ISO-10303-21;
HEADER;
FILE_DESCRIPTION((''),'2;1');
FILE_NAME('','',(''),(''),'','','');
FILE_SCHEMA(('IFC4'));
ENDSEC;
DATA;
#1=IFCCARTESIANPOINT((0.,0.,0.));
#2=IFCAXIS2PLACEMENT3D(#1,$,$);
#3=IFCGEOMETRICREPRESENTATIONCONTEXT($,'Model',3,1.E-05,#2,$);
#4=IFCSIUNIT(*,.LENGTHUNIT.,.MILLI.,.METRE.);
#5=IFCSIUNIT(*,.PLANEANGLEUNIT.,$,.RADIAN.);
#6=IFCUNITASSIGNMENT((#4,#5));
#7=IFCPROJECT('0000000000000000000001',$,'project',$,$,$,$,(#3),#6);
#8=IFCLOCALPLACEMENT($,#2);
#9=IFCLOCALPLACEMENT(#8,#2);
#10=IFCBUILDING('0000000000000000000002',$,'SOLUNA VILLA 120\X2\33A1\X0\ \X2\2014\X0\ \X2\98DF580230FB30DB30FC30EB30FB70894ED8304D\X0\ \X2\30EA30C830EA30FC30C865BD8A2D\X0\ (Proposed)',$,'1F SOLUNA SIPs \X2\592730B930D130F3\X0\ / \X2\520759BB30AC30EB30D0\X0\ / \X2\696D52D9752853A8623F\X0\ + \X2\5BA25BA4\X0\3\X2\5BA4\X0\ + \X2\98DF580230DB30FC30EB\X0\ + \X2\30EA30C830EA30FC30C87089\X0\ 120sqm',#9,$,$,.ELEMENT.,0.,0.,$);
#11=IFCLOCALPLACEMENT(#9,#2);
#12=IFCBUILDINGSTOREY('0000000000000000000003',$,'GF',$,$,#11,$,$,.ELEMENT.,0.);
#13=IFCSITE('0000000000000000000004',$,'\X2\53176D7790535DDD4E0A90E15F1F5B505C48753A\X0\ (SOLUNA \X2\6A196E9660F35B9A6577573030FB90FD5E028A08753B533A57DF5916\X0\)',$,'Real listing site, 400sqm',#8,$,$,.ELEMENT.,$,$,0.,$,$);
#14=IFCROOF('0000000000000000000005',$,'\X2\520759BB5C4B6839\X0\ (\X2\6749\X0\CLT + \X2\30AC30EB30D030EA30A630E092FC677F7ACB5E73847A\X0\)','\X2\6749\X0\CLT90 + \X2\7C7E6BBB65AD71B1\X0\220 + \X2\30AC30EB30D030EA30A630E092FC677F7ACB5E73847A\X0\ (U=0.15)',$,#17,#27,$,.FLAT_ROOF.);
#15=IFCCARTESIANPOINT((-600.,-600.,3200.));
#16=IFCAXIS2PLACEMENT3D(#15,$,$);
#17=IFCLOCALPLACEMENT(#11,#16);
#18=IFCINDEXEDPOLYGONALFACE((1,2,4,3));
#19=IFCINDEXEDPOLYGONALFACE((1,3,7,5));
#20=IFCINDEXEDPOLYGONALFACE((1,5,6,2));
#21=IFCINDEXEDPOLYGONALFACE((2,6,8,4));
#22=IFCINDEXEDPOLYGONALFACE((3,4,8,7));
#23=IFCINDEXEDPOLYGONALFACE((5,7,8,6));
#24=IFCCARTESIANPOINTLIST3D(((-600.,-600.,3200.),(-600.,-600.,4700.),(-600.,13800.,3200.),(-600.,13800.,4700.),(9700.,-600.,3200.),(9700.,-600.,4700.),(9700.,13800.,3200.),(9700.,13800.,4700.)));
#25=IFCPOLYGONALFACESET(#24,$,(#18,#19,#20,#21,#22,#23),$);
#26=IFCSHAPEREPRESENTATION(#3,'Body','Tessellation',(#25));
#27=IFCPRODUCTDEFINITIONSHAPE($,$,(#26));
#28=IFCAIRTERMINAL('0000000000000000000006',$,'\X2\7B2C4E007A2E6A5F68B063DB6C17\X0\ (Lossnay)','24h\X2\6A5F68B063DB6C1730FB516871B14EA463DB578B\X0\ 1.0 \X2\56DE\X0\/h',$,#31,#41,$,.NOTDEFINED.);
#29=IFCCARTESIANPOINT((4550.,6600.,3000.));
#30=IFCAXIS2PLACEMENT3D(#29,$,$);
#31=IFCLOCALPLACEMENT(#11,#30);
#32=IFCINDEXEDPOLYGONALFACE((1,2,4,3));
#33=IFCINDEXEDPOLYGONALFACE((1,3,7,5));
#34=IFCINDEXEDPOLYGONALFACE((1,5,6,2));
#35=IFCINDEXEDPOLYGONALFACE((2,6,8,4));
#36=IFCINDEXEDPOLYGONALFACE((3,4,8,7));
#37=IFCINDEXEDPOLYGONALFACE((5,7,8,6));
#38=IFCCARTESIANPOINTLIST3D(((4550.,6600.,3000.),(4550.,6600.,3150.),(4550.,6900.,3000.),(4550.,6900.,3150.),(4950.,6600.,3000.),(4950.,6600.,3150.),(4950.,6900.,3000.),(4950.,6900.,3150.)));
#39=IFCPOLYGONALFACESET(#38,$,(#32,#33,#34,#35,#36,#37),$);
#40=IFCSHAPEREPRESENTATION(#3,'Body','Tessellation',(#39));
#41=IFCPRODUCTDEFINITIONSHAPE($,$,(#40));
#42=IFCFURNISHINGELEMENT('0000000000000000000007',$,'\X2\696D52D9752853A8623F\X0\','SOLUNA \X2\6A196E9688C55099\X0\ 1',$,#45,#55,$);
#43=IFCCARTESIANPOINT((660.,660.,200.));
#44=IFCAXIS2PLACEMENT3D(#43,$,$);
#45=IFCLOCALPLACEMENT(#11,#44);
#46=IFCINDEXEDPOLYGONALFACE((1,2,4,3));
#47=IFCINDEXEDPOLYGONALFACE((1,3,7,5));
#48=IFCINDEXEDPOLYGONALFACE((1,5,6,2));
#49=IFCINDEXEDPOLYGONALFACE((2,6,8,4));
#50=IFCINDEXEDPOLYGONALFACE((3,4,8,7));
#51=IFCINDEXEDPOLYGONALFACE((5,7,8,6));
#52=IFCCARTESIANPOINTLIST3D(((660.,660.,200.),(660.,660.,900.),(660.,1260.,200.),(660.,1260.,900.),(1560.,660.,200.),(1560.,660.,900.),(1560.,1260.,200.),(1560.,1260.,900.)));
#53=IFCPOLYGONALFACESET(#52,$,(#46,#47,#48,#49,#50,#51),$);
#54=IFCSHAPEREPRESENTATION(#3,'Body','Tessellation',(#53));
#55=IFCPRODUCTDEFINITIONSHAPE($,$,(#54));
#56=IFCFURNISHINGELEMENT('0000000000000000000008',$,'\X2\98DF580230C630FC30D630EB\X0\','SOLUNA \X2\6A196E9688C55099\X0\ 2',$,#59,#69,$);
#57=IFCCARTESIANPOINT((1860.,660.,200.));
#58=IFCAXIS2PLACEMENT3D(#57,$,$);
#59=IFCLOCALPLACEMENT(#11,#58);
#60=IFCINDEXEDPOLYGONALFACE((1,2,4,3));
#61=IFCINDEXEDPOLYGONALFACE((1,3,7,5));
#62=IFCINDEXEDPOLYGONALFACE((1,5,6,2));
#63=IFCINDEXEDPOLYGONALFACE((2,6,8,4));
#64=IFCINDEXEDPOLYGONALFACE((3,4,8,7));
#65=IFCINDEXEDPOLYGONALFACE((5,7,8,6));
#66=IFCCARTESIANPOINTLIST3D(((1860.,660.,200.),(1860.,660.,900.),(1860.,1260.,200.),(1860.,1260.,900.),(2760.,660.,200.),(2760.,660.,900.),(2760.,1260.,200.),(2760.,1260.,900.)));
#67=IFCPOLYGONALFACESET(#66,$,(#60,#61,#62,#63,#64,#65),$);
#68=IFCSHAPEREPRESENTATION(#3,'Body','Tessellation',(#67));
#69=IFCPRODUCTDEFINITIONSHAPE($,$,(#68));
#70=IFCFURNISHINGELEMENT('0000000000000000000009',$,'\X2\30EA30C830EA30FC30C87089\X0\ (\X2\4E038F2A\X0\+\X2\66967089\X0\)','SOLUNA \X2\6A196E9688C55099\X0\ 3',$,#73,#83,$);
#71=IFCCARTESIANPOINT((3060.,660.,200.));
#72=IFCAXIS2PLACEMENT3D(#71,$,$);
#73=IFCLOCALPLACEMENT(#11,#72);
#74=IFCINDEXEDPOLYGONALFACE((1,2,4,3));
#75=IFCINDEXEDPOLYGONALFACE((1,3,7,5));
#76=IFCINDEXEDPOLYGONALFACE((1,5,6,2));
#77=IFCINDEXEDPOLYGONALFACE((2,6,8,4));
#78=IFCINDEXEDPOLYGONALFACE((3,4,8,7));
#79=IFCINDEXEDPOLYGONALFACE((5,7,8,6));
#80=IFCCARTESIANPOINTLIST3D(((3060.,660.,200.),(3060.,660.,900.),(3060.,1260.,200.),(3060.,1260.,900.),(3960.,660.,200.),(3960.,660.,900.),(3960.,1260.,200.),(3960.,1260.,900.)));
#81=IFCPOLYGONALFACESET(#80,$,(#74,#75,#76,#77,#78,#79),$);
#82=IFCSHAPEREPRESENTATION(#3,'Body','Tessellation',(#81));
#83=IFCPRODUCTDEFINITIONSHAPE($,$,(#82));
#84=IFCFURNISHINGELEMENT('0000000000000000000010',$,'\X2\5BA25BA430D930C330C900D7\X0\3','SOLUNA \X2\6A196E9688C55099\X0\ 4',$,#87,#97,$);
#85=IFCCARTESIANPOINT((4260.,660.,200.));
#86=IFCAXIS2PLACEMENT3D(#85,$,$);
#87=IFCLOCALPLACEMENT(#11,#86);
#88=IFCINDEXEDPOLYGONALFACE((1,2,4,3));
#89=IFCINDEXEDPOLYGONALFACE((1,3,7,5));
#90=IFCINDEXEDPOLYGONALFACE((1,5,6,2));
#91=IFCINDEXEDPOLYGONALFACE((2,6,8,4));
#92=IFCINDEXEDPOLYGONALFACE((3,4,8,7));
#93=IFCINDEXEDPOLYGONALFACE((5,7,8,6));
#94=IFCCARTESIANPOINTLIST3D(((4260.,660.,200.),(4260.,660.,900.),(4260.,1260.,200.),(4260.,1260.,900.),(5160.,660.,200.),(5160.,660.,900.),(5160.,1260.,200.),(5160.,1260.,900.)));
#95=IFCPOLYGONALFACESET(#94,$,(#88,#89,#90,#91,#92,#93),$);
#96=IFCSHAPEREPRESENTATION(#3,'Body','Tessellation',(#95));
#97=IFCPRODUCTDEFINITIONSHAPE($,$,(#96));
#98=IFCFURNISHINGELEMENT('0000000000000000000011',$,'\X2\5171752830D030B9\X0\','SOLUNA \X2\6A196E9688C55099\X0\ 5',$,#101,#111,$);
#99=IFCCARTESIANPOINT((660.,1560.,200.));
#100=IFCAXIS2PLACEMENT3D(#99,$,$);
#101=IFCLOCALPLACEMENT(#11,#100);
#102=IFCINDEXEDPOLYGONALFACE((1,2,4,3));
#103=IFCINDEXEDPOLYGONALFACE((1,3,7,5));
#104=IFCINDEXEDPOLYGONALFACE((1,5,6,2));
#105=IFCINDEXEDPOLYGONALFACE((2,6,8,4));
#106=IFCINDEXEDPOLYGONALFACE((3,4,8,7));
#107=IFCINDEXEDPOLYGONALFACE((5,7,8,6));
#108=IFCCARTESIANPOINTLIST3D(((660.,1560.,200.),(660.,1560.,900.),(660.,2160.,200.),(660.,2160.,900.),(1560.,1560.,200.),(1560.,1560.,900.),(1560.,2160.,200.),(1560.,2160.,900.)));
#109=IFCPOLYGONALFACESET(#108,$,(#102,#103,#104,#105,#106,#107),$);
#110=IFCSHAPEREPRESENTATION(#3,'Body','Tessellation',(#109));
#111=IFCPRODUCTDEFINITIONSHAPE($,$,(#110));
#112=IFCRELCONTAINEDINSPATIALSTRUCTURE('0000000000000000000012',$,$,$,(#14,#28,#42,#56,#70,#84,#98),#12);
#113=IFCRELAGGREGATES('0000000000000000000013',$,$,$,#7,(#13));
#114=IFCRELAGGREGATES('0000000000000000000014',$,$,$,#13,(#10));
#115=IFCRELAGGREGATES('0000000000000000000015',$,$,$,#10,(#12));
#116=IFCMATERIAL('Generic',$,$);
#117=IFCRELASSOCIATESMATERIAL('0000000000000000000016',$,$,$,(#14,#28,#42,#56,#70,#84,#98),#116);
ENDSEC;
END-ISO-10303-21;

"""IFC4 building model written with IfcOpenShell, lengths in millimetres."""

from ifc_helpers import new_model, si_unit, frame, frame_2d, origin, place, context, project, spatial, rectangle, extrude, material, element, save


model = new_model("IFC4")

# Units and contexts
model_context = context("Model", 3, precision=1e-05, world=origin())
ifc_project = project(units=[si_unit("LENGTHUNIT", "METRE", prefix="MILLI"), si_unit("PLANEANGLEUNIT", "RADIAN")], contexts=[model_context])

# Site, building, storey
site_placement = place(None, origin())
site = spatial("IfcSite", under=ifc_project, at=site_placement, Name="北海道川上郡弟子屈町 (SOLUNA 標準想定敷地・都市計画区域外)", ObjectType="Real listing site, 400sqm", CompositionType="ELEMENT", RefElevation=0.0)
building_placement = place(site_placement, origin())
building = spatial("IfcBuilding", under=site, at=building_placement, Name="SOLUNA VILLA 120㎡ — 食堂・ホール・炉付き リトリート施設 (Proposed)", ObjectType="1F SOLUNA SIPs 大スパン / 切妻ガルバ / 業務用厨房 + 客室3室 + 食堂ホール + リトリート炉 120sqm", CompositionType="ELEMENT", ElevationOfRefHeight=0.0, ElevationOfTerrain=0.0)
storey_placement = place(building_placement, origin())
storey = spatial("IfcBuildingStorey", under=building, at=storey_placement, Name="GF", CompositionType="ELEMENT", Elevation=0.0)

# Shared definitions
ifc_material_1 = material(Name="Generic")

# Roof
roof_placement = place(storey_placement, frame((-600.0, -600.0, 3200.0)))
element("IfcRoof", 1, at=roof_placement, inside=storey, material=ifc_material_1, Name="切妻屋根 (杉CLT + ガルバリウム鋼板立平葺)", Description="杉CLT90 + 籾殻断熱220 + ガルバリウム鋼板立平葺 (U=0.15)", PredefinedType="FLAT_ROOF", context=model_context, shape_type="SweptSolid", body=[
    extrude(rectangle(XDim=10300.0, YDim=14400.0, at=frame_2d((5150.0, 7200.0))), frame((-600.0, -600.0, 3200.0)), (0.0, 0.0, 1.0), 1500.0),
])

# Air terminal
air_terminal_placement = place(storey_placement, frame((4550.0, 6600.0, 3000.0)))
element("IfcAirTerminal", 2, at=air_terminal_placement, inside=storey, material=ifc_material_1, Name="第一種機械換気 (Lossnay)", Description="24h機械換気・全熱交換型 1.0 回/h", PredefinedType="NOTDEFINED", context=model_context, shape_type="SweptSolid", body=[
    extrude(rectangle(XDim=400.0, YDim=300.0, at=frame_2d((200.0, 150.0))), frame((4550.0, 6600.0, 3000.0)), (0.0, 0.0, 1.0), 150.0),
])

# Furnishing elements
furnishing_1_placement = place(storey_placement, frame((660.0, 660.0, 200.0)))
element("IfcFurnishingElement", 3, at=furnishing_1_placement, inside=storey, material=ifc_material_1, Name="業務用厨房", Description="SOLUNA 標準装備 1", context=model_context, shape_type="SweptSolid", body=[
    extrude(rectangle(XDim=900.0, YDim=600.0, at=frame_2d((450.0, 300.0))), frame((660.0, 660.0, 200.0)), (0.0, 0.0, 1.0), 700.0),
])
furnishing_2_placement = place(storey_placement, frame((1860.0, 660.0, 200.0)))
element("IfcFurnishingElement", 4, at=furnishing_2_placement, inside=storey, material=ifc_material_1, Name="食堂テーブル", Description="SOLUNA 標準装備 2", context=model_context, shape_type="SweptSolid", body=[
    extrude(rectangle(XDim=900.0, YDim=600.0, at=frame_2d((450.0, 300.0))), frame((1860.0, 660.0, 200.0)), (0.0, 0.0, 1.0), 700.0),
])
furnishing_3_placement = place(storey_placement, frame((3060.0, 660.0, 200.0)))
element("IfcFurnishingElement", 5, at=furnishing_3_placement, inside=storey, material=ifc_material_1, Name="リトリート炉 (七輪+暖炉)", Description="SOLUNA 標準装備 3", context=model_context, shape_type="SweptSolid", body=[
    extrude(rectangle(XDim=900.0, YDim=600.0, at=frame_2d((450.0, 300.0))), frame((3060.0, 660.0, 200.0)), (0.0, 0.0, 1.0), 700.0),
])
furnishing_4_placement = place(storey_placement, frame((4260.0, 660.0, 200.0)))
element("IfcFurnishingElement", 6, at=furnishing_4_placement, inside=storey, material=ifc_material_1, Name="客室ベッド×3", Description="SOLUNA 標準装備 4", context=model_context, shape_type="SweptSolid", body=[
    extrude(rectangle(XDim=900.0, YDim=600.0, at=frame_2d((450.0, 300.0))), frame((4260.0, 660.0, 200.0)), (0.0, 0.0, 1.0), 700.0),
])
furnishing_5_placement = place(storey_placement, frame((660.0, 1560.0, 200.0)))
element("IfcFurnishingElement", 7, at=furnishing_5_placement, inside=storey, material=ifc_material_1, Name="共用バス", Description="SOLUNA 標準装備 5", context=model_context, shape_type="SweptSolid", body=[
    extrude(rectangle(XDim=900.0, YDim=600.0, at=frame_2d((450.0, 300.0))), frame((660.0, 1560.0, 200.0)), (0.0, 0.0, 1.0), 700.0),
])

save(model, "model.ifc")
